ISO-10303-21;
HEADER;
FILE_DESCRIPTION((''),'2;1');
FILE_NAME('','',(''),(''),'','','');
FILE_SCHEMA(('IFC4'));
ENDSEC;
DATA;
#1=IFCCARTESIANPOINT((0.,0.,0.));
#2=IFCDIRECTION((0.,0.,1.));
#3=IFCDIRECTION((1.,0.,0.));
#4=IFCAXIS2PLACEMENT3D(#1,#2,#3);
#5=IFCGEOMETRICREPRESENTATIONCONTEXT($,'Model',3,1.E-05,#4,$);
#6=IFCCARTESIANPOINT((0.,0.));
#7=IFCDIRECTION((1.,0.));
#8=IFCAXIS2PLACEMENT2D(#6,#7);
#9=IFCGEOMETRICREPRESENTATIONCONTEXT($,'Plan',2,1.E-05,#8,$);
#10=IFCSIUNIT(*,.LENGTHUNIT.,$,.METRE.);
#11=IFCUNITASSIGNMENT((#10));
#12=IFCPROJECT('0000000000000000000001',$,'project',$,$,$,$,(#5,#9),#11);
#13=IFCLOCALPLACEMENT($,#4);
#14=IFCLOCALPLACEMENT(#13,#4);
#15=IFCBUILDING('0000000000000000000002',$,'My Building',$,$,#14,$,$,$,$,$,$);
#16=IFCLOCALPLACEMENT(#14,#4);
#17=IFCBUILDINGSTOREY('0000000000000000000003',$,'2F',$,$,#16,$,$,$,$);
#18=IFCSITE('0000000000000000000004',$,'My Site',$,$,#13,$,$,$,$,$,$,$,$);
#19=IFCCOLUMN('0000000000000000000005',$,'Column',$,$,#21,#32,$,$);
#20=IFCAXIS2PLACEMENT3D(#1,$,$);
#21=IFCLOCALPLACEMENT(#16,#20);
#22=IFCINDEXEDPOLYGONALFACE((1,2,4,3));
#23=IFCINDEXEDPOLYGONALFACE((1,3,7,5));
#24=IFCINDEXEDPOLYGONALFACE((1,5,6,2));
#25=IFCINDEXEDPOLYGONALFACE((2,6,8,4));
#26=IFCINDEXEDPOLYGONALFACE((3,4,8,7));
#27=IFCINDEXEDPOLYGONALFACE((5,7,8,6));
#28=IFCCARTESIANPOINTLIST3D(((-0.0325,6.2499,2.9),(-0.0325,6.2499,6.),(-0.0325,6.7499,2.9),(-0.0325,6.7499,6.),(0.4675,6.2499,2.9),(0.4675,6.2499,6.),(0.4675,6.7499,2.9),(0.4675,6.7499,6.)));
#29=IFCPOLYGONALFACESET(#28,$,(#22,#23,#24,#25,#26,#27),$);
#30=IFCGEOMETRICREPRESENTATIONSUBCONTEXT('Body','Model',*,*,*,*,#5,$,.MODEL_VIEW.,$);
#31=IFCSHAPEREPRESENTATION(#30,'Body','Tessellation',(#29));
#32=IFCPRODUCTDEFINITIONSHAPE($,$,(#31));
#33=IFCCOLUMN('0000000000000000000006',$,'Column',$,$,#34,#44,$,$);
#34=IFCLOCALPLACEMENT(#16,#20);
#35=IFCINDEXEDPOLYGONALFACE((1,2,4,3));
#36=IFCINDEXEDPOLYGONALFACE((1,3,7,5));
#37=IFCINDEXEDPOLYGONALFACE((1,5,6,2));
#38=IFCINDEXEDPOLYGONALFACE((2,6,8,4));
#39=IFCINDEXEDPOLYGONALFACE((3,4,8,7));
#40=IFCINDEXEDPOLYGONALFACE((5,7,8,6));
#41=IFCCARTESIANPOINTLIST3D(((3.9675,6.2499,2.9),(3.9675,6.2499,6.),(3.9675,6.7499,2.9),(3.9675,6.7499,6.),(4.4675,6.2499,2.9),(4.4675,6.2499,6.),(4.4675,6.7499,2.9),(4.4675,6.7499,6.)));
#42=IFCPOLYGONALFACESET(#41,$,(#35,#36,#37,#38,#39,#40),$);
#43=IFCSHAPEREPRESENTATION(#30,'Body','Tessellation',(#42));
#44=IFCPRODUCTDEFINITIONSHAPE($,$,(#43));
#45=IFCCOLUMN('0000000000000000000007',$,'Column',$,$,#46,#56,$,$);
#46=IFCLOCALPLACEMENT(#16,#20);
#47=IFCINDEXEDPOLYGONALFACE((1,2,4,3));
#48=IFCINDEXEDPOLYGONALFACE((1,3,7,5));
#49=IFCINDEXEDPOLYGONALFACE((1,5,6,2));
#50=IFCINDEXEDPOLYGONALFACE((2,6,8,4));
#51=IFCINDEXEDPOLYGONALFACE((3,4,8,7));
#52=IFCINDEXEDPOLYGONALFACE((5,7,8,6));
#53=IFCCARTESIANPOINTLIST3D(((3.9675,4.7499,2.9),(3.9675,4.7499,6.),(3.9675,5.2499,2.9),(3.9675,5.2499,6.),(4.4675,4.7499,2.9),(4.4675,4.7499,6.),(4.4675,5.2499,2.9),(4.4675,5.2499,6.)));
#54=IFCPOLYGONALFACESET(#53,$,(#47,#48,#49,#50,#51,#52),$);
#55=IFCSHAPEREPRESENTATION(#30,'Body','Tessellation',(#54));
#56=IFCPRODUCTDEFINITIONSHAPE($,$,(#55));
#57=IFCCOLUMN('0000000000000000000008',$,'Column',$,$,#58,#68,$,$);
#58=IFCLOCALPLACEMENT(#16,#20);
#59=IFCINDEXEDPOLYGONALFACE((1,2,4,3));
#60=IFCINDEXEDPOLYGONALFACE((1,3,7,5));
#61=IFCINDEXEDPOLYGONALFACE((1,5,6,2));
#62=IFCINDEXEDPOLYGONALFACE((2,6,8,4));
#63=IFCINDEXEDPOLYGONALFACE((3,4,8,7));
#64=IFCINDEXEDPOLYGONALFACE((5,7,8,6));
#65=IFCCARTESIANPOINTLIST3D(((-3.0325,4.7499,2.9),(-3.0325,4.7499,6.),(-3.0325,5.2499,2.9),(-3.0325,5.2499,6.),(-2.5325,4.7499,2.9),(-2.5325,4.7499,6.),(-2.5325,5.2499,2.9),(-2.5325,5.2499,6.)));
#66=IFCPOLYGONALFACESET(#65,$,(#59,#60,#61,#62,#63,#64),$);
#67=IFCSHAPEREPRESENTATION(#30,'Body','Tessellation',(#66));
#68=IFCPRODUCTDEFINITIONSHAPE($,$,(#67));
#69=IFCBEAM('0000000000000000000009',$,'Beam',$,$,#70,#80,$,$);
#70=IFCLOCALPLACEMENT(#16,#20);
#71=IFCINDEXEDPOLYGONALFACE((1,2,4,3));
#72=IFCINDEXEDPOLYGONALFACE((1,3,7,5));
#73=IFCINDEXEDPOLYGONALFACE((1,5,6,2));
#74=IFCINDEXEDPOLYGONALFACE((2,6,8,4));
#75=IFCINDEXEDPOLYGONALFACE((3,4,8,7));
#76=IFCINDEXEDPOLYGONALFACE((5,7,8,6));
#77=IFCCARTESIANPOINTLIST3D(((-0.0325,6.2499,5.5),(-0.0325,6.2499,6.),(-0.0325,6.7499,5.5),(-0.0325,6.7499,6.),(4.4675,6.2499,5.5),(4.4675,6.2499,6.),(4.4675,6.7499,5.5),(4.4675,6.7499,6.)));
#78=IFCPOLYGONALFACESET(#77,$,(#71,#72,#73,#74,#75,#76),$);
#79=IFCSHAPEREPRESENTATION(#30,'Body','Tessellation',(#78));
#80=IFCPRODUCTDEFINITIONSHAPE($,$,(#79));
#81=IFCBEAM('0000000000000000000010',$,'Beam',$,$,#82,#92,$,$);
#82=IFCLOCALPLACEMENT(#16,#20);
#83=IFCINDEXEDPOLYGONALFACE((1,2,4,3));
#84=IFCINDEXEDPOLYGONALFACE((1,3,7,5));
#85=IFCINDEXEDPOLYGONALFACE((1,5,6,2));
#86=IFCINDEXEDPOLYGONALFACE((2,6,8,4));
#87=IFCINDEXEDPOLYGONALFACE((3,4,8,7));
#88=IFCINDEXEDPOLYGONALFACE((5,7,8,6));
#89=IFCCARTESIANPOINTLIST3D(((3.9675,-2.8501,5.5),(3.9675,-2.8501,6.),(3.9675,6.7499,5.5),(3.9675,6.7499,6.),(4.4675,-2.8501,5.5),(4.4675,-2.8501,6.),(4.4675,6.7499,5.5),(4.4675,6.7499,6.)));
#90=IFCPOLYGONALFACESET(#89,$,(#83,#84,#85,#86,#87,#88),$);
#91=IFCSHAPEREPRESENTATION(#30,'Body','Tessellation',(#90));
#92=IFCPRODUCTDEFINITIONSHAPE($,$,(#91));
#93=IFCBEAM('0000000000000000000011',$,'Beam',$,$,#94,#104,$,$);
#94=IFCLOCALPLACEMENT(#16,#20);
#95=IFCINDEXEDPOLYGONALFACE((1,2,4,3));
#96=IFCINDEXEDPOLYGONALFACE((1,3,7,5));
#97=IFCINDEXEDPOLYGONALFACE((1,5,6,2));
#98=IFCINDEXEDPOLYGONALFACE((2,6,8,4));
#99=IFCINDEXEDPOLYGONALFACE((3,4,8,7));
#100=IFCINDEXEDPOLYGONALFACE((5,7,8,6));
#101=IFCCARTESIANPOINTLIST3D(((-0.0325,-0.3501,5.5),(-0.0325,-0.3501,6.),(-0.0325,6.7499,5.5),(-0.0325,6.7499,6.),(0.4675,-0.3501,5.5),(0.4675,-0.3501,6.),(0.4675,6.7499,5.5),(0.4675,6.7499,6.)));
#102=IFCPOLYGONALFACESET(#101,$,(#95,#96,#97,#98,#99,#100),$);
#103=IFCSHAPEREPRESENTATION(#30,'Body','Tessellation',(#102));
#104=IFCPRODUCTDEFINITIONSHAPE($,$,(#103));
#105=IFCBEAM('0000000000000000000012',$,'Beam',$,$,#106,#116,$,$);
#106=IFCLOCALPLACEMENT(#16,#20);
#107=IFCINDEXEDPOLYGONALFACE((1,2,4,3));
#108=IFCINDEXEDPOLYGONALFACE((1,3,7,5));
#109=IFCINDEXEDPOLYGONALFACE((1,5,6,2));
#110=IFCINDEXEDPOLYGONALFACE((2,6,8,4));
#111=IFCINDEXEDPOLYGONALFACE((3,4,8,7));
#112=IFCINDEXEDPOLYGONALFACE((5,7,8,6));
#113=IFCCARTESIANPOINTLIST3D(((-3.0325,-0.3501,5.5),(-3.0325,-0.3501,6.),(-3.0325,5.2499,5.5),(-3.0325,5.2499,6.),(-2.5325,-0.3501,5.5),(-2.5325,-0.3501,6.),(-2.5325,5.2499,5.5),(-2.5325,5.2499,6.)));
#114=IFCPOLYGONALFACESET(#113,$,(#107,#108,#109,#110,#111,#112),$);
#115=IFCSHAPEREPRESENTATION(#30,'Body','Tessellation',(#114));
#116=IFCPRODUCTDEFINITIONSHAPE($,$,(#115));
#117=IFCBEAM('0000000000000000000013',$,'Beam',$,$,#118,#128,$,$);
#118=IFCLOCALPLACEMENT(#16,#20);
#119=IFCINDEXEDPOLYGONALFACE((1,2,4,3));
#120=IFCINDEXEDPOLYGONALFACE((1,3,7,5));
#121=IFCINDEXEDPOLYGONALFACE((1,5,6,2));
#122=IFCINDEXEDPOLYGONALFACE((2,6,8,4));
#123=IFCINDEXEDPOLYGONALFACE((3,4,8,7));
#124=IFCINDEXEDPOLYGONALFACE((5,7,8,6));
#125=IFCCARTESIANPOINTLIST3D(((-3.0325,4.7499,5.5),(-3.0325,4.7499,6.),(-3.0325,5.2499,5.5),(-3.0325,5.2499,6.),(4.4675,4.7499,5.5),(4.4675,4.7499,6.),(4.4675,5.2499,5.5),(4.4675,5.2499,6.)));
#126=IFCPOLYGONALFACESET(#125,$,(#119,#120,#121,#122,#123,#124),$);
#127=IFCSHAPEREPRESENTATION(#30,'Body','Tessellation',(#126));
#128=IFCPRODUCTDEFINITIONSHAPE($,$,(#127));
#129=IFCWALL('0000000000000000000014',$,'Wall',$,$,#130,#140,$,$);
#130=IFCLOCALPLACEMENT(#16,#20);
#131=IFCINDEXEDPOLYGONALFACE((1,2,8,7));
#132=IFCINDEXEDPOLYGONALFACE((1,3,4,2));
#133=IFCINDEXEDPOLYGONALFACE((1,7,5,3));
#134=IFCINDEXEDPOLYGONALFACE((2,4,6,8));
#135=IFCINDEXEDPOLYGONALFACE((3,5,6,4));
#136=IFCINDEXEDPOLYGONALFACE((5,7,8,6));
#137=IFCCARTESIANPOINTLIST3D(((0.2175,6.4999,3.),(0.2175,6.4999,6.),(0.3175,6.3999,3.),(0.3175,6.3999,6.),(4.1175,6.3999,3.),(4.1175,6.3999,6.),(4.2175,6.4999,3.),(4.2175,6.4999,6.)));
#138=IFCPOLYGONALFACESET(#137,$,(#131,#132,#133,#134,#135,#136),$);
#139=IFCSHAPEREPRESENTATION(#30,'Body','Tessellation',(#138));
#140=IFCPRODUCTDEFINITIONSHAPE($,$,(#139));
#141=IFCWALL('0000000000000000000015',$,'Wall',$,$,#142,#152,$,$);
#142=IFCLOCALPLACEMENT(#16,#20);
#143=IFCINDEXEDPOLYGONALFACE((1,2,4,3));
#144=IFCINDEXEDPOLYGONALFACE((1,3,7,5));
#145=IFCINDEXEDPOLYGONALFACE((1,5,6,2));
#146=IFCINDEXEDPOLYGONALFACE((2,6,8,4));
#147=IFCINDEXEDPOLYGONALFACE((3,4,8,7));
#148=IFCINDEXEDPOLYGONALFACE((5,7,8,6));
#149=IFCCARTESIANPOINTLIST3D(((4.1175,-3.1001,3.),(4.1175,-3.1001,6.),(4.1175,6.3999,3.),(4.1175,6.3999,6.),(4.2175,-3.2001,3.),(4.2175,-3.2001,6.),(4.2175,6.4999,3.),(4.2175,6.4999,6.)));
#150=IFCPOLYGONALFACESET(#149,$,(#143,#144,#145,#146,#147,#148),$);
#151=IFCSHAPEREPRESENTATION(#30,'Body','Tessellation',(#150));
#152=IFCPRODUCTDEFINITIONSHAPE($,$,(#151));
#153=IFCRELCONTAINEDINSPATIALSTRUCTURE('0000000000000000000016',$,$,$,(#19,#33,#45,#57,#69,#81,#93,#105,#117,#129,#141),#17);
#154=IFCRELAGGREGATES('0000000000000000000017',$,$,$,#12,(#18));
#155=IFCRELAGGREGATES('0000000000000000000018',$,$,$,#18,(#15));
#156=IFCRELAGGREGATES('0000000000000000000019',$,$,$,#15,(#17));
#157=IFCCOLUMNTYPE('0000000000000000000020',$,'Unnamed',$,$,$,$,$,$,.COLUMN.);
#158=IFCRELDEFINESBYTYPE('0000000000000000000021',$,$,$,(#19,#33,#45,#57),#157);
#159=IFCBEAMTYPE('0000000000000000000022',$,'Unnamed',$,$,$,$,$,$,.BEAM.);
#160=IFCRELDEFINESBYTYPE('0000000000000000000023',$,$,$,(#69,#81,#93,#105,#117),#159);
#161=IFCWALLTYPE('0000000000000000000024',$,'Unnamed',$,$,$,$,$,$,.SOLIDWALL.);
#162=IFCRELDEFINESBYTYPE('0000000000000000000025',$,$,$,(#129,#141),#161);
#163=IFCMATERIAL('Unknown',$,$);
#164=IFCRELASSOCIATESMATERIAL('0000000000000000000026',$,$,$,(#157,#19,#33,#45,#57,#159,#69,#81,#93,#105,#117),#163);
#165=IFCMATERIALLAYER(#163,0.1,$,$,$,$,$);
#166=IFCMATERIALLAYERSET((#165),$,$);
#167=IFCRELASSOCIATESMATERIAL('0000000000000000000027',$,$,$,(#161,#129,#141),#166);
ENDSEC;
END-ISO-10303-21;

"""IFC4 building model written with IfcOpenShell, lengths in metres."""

from ifc_helpers import new_model, si_unit, frame, origin_with_axes, origin_2d_with_axis, place, context, subcontext, project, spatial, line, indexed_curve, rectangle, outline, extrude, material, layer, layer_set, layer_usage, material_profile, profile_set, profile_usage, type_object, element, save


model = new_model("IFC4")

# Units and contexts
model_context = context("Model", 3, precision=1e-05, world=origin_with_axes())
plan_context = context("Plan", 2, precision=1e-05, world=origin_2d_with_axis())
body_context_1 = subcontext(model_context, "Body", "Model", "MODEL_VIEW")
ifc_project = project(units=[si_unit("LENGTHUNIT", "METRE")], contexts=[model_context, plan_context])

# Site, building, storey
site_placement = place(None, origin_with_axes())
site = spatial("IfcSite", under=ifc_project, at=site_placement, Name="My Site")
building_placement = place(site_placement, origin_with_axes())
building = spatial("IfcBuilding", under=site, at=building_placement, Name="My Building")
storey_placement = place(building_placement, origin_with_axes())
storey = spatial("IfcBuildingStorey", under=building, at=storey_placement, Name="2F")

# Columns
ifc_material = material(Name="Unknown")
ifc_material_profile_1 = material_profile(ifc_material, rectangle(XDim=0.5, YDim=0.5))
ifc_profile_set_1 = profile_set([ifc_material_profile_1])
ifc_profile_usage_1 = profile_usage(ifc_profile_set_1, cardinal=5)
column_type = type_object("IfcColumnType", Name="Unnamed", PredefinedType="COLUMN", material=ifc_profile_set_1)
column_1_placement = place(storey_placement, frame((0.2175, 6.4999, 2.9), z_axis=(0.0, 0.0, 1.0), x_axis=(1.0, 0.0, 0.0)))
element("IfcColumn", 1, at=column_1_placement, inside=storey, type_object=column_type, material=ifc_profile_usage_1, Name="Column", context=body_context_1, shape_type="SweptSolid", body=[
    extrude(rectangle(XDim=0.5, YDim=0.5), origin_with_axes(), (0.0, 0.0, 1.0), 3.1),
])
ifc_profile_usage_2 = profile_usage(ifc_profile_set_1, cardinal=5)
column_2_placement = place(storey_placement, frame((4.2175, 6.4999, 2.9), z_axis=(0.0, 0.0, 1.0), x_axis=(1.0, 0.0, 0.0)))
element("IfcColumn", 2, at=column_2_placement, inside=storey, type_object=column_type, material=ifc_profile_usage_2, Name="Column", context=body_context_1, shape_type="SweptSolid", body=[
    extrude(rectangle(XDim=0.5, YDim=0.5), origin_with_axes(), (0.0, 0.0, 1.0), 3.1),
])
ifc_profile_usage_3 = profile_usage(ifc_profile_set_1, cardinal=5)
column_3_placement = place(storey_placement, frame((4.2175, 4.9999, 2.9), z_axis=(0.0, 0.0, 1.0), x_axis=(1.0, 0.0, 0.0)))
element("IfcColumn", 3, at=column_3_placement, inside=storey, type_object=column_type, material=ifc_profile_usage_3, Name="Column", context=body_context_1, shape_type="SweptSolid", body=[
    extrude(rectangle(XDim=0.5, YDim=0.5), origin_with_axes(), (0.0, 0.0, 1.0), 3.1),
])
ifc_profile_usage_4 = profile_usage(ifc_profile_set_1, cardinal=5)
column_4_placement = place(storey_placement, frame((-2.7825, 4.9999, 2.9), z_axis=(0.0, 0.0, 1.0), x_axis=(1.0, 0.0, 0.0)))
element("IfcColumn", 4, at=column_4_placement, inside=storey, type_object=column_type, material=ifc_profile_usage_4, Name="Column", context=body_context_1, shape_type="SweptSolid", body=[
    extrude(rectangle(XDim=0.5, YDim=0.5), origin_with_axes(), (0.0, 0.0, 1.0), 3.1),
])

# Beams
ifc_material_profile_2 = material_profile(ifc_material, rectangle(XDim=0.5, YDim=0.5))
ifc_profile_set_2 = profile_set([ifc_material_profile_2])
ifc_profile_usage_5 = profile_usage(ifc_profile_set_2, cardinal=5)
beam_type = type_object("IfcBeamType", Name="Unnamed", PredefinedType="BEAM", material=ifc_profile_set_2)
beam_1_placement = place(storey_placement, frame((-0.0325, 6.4999, 5.75), z_axis=(1.0, 0.0, 0.0), x_axis=(0.0, 1.0, 0.0)))
element("IfcBeam", 5, at=beam_1_placement, inside=storey, type_object=beam_type, material=ifc_profile_usage_5, Name="Beam", context=body_context_1, shape_type="SweptSolid", body=[
    extrude(rectangle(XDim=0.5, YDim=0.5), origin_with_axes(), (0.0, 0.0, 1.0), 4.5),
])
ifc_profile_usage_6 = profile_usage(ifc_profile_set_2, cardinal=5)
beam_2_placement = place(storey_placement, frame((4.2175, 6.7499, 5.75), z_axis=(0.0, -1.0, 0.0), x_axis=(1.0, 0.0, 0.0)))
element("IfcBeam", 6, at=beam_2_placement, inside=storey, type_object=beam_type, material=ifc_profile_usage_6, Name="Beam", context=body_context_1, shape_type="SweptSolid", body=[
    extrude(rectangle(XDim=0.5, YDim=0.5), origin_with_axes(), (0.0, 0.0, 1.0), 9.6),
])
ifc_profile_usage_7 = profile_usage(ifc_profile_set_2, cardinal=5)
beam_3_placement = place(storey_placement, frame((0.2175, 6.7499, 5.75), z_axis=(0.0, -1.0, 0.0), x_axis=(1.0, 0.0, 0.0)))
element("IfcBeam", 7, at=beam_3_placement, inside=storey, type_object=beam_type, material=ifc_profile_usage_7, Name="Beam", context=body_context_1, shape_type="SweptSolid", body=[
    extrude(rectangle(XDim=0.5, YDim=0.5), origin_with_axes(), (0.0, 0.0, 1.0), 7.1),
])
ifc_profile_usage_8 = profile_usage(ifc_profile_set_2, cardinal=5)
beam_4_placement = place(storey_placement, frame((-2.7825, 5.2499, 5.75), z_axis=(0.0, -1.0, 0.0), x_axis=(1.0, 0.0, 0.0)))
element("IfcBeam", 8, at=beam_4_placement, inside=storey, type_object=beam_type, material=ifc_profile_usage_8, Name="Beam", context=body_context_1, shape_type="SweptSolid", body=[
    extrude(rectangle(XDim=0.5, YDim=0.5), origin_with_axes(), (0.0, 0.0, 1.0), 5.6),
])
ifc_profile_usage_9 = profile_usage(ifc_profile_set_2, cardinal=5)
beam_5_placement = place(storey_placement, frame((-3.0325, 4.9999, 5.75), z_axis=(1.0, 0.0, 0.0), x_axis=(0.0, 1.0, 0.0)))
element("IfcBeam", 9, at=beam_5_placement, inside=storey, type_object=beam_type, material=ifc_profile_usage_9, Name="Beam", context=body_context_1, shape_type="SweptSolid", body=[
    extrude(rectangle(XDim=0.5, YDim=0.5), origin_with_axes(), (0.0, 0.0, 1.0), 7.5),
])

# Walls
ifc_layer = layer(ifc_material, 0.1)
ifc_layer_set = layer_set([ifc_layer])
ifc_layer_usage_1 = layer_usage(ifc_layer_set, "AXIS2", "POSITIVE", 0.0)
wall_type = type_object("IfcWallType", Name="Unnamed", PredefinedType="SOLIDWALL", material=ifc_layer_set)
wall_1_placement = place(storey_placement, frame((0.3175, 6.3999, 3.0), z_axis=(0.0, 0.0, 1.0), x_axis=(1.0, 0.0, 0.0)))
element("IfcWall", 10, at=wall_1_placement, inside=storey, type_object=wall_type, material=ifc_layer_usage_1, Name="Wall", context=body_context_1, shape_type="SweptSolid", body=[
    extrude(outline(indexed_curve([(0.0, 0.0), (-0.1, 0.1), (3.9, 0.1), (3.8, 0.0)], segments=[line(1, 2, 3, 4, 1)])), origin_with_axes(), (0.0, 0.0, 1.0), 3.0),
])
ifc_layer_usage_2 = layer_usage(ifc_layer_set, "AXIS2", "POSITIVE", 0.0)
wall_2_placement = place(storey_placement, frame((4.1175, 6.3999, 3.0), z_axis=(0.0, 0.0, 1.0), x_axis=(0.0, -1.0, 0.0)))
element("IfcWall", 11, at=wall_2_placement, inside=storey, type_object=wall_type, material=ifc_layer_usage_2, Name="Wall", context=body_context_1, shape_type="SweptSolid", body=[
    extrude(outline(indexed_curve([(0.0, 0.0), (-0.1, 0.1), (9.6, 0.1), (9.5, 0.0)], segments=[line(1, 2, 3, 4, 1)])), origin_with_axes(), (0.0, 0.0, 1.0), 3.0),
])

save(model, "model.ifc")
